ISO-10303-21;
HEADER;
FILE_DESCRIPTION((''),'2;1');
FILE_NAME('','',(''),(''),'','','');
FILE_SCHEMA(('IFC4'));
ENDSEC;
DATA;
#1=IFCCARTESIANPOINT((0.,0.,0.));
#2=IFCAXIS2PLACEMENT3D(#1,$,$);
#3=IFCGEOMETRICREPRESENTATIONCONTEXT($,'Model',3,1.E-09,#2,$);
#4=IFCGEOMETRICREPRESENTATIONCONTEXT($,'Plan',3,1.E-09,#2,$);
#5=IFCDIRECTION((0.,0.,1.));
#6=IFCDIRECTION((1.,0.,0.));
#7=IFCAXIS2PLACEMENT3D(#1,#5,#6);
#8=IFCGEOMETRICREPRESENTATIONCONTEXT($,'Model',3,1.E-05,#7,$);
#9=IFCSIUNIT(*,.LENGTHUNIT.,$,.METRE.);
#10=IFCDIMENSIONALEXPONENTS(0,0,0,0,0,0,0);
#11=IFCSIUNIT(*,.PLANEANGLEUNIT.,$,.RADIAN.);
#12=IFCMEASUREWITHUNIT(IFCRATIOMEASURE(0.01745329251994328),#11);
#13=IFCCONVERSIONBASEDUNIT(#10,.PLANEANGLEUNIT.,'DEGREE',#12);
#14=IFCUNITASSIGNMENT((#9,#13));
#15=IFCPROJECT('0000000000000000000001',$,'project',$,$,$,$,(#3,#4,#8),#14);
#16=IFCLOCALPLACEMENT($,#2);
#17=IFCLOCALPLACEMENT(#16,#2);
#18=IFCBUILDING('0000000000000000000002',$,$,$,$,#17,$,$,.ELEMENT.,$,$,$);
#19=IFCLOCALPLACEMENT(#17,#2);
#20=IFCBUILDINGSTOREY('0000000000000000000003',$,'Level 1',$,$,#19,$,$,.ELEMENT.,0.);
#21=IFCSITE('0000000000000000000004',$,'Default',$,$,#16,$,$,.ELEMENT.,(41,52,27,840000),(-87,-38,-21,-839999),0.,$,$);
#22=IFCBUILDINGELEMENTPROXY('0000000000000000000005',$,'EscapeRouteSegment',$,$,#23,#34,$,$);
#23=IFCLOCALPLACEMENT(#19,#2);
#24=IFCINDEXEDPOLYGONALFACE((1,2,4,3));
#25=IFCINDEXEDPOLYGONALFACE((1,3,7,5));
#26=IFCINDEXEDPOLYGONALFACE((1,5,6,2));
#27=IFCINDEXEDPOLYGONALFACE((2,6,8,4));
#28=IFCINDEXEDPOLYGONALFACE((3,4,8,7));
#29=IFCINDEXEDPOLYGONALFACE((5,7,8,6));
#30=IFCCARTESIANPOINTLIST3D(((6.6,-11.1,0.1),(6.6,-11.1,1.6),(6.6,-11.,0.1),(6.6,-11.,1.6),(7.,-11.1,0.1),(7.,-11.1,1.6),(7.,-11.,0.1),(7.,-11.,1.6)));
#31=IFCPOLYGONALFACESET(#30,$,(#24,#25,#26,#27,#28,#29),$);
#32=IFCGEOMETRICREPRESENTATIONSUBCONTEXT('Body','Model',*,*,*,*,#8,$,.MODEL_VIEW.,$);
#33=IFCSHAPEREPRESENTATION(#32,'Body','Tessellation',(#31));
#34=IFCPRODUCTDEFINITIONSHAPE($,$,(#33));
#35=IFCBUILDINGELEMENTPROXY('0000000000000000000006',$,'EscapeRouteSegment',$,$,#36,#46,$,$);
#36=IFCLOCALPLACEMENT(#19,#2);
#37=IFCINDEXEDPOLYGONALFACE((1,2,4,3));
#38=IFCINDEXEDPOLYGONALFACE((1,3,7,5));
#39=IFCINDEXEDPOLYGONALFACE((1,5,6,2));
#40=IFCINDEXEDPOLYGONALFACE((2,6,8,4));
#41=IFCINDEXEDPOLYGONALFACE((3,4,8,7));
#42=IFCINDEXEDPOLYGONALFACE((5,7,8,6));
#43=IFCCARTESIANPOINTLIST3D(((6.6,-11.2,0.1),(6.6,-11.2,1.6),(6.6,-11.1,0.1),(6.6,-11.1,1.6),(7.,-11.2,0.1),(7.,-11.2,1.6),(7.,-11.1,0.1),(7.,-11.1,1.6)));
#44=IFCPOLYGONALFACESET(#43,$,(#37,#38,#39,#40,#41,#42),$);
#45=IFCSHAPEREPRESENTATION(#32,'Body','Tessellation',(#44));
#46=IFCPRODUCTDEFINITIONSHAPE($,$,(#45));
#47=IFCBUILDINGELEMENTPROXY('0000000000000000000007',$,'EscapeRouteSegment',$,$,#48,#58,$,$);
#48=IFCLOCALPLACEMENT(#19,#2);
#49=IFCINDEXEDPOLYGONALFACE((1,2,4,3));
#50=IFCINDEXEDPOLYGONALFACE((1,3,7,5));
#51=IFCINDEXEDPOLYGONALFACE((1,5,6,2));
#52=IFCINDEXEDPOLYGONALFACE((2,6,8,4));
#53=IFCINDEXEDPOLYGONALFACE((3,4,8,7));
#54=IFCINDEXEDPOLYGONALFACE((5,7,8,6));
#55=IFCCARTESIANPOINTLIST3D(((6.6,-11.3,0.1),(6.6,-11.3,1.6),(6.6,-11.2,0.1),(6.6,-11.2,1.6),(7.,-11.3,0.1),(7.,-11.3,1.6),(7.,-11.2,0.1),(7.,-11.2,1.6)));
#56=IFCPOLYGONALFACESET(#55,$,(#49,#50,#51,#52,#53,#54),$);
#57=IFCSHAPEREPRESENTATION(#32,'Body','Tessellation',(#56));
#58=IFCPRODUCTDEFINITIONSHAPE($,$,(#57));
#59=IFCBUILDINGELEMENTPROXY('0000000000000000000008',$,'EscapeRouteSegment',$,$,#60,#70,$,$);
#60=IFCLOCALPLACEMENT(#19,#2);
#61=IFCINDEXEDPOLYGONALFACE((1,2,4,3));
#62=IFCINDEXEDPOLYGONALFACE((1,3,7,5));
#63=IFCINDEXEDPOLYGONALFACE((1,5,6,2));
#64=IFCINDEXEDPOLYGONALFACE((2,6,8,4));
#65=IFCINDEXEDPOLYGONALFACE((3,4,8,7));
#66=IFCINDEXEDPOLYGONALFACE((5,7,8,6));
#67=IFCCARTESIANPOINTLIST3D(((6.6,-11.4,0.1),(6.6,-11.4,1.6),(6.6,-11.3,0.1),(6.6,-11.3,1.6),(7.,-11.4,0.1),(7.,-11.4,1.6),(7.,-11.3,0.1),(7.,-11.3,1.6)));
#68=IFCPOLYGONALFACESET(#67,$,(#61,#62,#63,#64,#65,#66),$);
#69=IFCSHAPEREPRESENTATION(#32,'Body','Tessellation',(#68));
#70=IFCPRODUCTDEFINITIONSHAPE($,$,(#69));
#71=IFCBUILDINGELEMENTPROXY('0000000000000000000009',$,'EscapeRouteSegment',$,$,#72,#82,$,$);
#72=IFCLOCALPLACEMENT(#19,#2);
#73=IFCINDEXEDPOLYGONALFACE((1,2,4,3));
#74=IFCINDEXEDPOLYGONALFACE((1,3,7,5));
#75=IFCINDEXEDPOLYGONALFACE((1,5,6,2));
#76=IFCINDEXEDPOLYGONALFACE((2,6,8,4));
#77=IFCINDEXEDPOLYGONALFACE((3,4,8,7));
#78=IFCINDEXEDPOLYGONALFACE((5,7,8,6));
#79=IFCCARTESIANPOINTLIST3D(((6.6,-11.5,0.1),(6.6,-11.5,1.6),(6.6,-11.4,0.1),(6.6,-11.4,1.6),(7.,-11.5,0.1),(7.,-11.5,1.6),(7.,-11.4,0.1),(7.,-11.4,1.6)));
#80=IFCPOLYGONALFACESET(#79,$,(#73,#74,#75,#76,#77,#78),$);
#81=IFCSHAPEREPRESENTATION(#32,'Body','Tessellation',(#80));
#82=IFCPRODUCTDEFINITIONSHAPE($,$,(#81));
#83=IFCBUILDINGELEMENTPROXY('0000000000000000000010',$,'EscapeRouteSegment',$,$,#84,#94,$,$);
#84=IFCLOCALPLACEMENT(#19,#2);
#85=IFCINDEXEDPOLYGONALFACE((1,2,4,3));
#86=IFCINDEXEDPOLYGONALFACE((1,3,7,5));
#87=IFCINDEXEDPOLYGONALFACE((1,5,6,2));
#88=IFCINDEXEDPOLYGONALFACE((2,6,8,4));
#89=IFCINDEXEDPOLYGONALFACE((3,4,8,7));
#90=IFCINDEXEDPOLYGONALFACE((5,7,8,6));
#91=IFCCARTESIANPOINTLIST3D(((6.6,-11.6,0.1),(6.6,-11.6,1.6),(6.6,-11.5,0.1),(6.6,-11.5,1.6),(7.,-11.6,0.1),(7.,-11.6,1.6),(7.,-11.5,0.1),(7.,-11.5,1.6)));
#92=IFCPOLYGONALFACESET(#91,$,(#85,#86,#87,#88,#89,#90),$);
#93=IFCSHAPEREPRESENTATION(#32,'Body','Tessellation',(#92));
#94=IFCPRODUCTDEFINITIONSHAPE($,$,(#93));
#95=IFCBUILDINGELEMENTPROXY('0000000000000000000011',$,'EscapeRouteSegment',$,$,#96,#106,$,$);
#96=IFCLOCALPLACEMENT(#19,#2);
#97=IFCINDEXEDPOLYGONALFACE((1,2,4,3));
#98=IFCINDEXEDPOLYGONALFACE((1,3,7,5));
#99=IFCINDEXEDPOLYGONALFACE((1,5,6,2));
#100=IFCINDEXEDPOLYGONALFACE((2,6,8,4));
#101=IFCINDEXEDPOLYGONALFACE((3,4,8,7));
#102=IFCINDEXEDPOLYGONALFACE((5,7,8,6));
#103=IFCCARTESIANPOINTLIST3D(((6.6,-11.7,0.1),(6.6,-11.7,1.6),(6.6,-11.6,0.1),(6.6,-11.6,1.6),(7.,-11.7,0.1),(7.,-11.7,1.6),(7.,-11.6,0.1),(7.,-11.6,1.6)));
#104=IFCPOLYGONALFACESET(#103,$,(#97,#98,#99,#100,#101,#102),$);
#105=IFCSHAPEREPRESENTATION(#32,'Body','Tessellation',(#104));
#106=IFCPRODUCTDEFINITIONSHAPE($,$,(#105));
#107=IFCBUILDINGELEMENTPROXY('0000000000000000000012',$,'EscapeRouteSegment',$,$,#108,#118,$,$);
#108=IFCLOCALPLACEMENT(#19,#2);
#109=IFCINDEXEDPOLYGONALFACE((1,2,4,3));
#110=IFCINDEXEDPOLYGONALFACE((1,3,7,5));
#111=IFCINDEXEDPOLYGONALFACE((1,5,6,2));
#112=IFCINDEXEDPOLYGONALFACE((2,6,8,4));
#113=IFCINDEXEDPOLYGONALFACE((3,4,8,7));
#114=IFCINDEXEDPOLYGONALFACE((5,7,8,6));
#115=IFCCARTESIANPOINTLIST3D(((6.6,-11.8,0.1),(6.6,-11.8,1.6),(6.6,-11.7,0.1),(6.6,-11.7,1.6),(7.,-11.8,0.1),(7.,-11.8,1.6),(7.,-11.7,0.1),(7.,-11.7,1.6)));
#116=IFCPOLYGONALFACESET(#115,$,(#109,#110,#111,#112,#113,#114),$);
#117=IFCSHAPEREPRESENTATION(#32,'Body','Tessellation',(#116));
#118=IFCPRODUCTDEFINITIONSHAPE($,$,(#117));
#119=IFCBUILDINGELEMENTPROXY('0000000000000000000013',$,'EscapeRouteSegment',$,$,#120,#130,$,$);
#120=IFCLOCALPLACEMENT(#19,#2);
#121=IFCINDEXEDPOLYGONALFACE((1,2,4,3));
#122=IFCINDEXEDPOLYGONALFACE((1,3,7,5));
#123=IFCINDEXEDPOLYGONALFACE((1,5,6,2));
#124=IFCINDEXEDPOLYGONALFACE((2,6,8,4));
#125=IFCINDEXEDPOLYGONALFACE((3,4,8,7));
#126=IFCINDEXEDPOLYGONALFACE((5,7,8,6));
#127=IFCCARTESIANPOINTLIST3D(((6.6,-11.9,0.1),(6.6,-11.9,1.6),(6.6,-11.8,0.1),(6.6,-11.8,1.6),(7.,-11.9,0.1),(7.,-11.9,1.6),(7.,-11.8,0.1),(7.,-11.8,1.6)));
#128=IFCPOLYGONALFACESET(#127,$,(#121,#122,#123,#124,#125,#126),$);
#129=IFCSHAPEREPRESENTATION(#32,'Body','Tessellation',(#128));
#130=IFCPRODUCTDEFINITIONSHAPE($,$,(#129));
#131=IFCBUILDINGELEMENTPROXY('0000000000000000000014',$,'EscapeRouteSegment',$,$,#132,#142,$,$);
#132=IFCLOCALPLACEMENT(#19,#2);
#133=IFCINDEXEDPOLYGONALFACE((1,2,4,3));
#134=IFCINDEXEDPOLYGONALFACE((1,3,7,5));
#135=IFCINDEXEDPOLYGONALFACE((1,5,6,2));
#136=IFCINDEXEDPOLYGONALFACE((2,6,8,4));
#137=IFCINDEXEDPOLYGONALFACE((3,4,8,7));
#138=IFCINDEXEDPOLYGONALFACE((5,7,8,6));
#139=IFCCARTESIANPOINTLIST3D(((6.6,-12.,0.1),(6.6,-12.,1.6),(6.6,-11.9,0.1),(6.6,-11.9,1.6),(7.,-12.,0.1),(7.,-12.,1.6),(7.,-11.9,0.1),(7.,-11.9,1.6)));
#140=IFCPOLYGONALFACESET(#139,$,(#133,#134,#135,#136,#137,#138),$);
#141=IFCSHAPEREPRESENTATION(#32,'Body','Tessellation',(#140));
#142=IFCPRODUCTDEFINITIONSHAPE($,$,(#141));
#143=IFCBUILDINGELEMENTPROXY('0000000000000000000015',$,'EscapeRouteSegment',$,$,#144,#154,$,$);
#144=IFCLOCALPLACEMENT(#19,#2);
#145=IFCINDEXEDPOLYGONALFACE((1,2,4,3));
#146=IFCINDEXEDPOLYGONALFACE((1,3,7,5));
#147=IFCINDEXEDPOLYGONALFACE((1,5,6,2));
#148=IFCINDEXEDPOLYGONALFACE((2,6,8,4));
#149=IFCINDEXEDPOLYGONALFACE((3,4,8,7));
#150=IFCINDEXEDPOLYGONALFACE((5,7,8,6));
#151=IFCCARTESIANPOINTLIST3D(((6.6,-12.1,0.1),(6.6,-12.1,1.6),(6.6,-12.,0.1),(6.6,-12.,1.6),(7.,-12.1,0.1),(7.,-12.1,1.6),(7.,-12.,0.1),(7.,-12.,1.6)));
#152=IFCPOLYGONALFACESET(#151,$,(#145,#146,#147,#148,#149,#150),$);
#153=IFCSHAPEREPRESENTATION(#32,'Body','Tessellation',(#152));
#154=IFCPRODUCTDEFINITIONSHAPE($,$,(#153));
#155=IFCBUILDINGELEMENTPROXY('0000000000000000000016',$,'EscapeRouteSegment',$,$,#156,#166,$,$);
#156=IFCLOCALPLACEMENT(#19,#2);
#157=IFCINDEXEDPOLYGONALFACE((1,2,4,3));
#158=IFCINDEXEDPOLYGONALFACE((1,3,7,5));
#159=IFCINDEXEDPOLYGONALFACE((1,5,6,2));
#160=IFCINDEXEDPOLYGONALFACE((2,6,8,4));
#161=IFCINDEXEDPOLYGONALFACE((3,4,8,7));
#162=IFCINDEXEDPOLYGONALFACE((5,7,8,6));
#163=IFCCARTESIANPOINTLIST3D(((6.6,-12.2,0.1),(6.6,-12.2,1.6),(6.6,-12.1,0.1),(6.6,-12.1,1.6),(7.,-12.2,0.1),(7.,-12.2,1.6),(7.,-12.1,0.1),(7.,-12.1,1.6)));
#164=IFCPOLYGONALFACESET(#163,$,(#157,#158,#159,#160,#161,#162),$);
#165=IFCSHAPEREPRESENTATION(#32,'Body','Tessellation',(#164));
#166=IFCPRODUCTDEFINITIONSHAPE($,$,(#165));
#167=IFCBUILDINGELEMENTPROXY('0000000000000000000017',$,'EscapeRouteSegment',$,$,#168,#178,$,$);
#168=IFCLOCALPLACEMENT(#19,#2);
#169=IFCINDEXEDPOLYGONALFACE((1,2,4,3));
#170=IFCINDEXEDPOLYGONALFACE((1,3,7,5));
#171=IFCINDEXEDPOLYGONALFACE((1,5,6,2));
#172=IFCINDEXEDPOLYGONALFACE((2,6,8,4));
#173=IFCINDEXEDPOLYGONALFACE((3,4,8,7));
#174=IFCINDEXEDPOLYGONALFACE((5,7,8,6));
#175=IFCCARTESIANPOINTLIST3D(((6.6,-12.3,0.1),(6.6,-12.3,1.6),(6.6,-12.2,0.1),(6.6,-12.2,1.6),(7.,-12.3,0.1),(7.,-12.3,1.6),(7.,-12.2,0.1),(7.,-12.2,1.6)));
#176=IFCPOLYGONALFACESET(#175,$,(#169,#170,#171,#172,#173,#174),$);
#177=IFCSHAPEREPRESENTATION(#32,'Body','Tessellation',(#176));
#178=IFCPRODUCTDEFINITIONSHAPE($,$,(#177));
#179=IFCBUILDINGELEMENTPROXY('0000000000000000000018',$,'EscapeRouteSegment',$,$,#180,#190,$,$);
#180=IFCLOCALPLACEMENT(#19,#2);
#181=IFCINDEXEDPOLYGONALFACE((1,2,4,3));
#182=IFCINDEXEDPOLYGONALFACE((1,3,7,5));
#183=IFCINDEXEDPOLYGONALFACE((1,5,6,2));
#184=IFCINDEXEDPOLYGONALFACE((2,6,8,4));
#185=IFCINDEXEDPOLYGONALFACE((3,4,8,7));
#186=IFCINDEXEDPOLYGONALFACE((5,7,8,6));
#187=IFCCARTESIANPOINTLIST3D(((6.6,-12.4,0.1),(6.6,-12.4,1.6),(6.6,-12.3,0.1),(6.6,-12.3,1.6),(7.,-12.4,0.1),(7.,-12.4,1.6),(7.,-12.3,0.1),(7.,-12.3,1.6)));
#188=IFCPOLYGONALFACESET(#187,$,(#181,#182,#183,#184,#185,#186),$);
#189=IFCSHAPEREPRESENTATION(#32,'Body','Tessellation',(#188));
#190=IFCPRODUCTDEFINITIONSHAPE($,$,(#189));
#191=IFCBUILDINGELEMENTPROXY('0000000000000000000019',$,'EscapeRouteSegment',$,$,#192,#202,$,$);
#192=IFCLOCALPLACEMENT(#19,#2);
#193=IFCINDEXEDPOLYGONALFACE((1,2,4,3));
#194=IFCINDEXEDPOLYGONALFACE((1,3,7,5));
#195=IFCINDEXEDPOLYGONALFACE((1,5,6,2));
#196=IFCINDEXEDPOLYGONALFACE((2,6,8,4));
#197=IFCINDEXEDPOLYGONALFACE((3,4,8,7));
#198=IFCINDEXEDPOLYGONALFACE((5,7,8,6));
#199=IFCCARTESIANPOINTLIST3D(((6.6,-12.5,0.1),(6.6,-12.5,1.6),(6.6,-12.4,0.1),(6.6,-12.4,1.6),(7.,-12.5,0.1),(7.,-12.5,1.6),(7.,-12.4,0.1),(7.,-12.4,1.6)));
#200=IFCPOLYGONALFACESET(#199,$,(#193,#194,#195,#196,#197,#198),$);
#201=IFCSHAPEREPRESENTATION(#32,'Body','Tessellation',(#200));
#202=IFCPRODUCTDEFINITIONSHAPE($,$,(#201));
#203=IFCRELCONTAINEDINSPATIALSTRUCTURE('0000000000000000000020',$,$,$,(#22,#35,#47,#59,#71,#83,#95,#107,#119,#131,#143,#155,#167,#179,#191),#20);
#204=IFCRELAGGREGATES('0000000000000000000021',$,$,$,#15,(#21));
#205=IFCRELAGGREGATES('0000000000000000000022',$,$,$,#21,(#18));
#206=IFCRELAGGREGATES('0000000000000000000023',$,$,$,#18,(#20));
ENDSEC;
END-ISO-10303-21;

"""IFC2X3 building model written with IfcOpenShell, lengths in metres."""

from ifc_helpers import new_model, entity, si_unit, converted_unit, frame, origin, origin_with_axes, place, context, subcontext, project, spatial, polyline, outline, extrude, element, save


model = new_model("IFC2X3")

# Units and contexts
model_context_1 = context("Model", 3, precision=1e-09, world=origin())
plan_context = context("Plan", 3, precision=1e-09, world=origin())
model_context_2 = context("Model", 3, precision=1e-05, world=origin_with_axes())
body_context = subcontext(model_context_2, "Body", "Model", "MODEL_VIEW")
ifc_project = project(units=[si_unit("LENGTHUNIT", "METRE"), converted_unit("PLANEANGLEUNIT", "DEGREE", entity("IfcRatioMeasure", 0.01745329251994328), si_unit("PLANEANGLEUNIT", "RADIAN"), dimensions=[0, 0, 0, 0, 0, 0, 0])], contexts=[model_context_1, plan_context, model_context_2])

# Site, building, storey
site_placement = place(None, origin())
site = spatial("IfcSite", under=ifc_project, at=site_placement, Name="Default", CompositionType="ELEMENT", RefLatitude=(41, 52, 27, 840000), RefLongitude=(-87, -38, -21, -839999), RefElevation=0.0)
building_placement = place(site_placement, origin())
building = spatial("IfcBuilding", under=site, at=building_placement, CompositionType="ELEMENT")
storey_placement = place(building_placement, origin())
storey = spatial("IfcBuildingStorey", under=building, at=storey_placement, Name="Level 1", CompositionType="ELEMENT", Elevation=0.0)

# Building element proxies
proxy_1_placement = place(storey_placement, frame((6.8, -11.0, 0.1), z_axis=(0.0, 0.0, 1.0), x_axis=(0.0, -1.0, 0.0)))
element("IfcBuildingElementProxy", 1, at=proxy_1_placement, inside=storey, Name="EscapeRouteSegment", context=body_context, shape_type="SweptSolid", body=[
    extrude(outline(polyline([(0.0, -0.2), (0.0, 0.2), (0.1, 0.2), (0.1, -0.2), (0.0, -0.2)])), origin_with_axes(), (0.0, 0.0, 1.0), 1.5),
])
proxy_2_placement = place(storey_placement, frame((6.8, -11.1, 0.1), z_axis=(0.0, 0.0, 1.0), x_axis=(0.0, -1.0, 0.0)))
element("IfcBuildingElementProxy", 2, at=proxy_2_placement, inside=storey, Name="EscapeRouteSegment", context=body_context, shape_type="SweptSolid", body=[
    extrude(outline(polyline([(0.0, -0.2), (0.0, 0.2), (0.1, 0.2), (0.1, -0.2), (0.0, -0.2)])), origin_with_axes(), (0.0, 0.0, 1.0), 1.5),
])
proxy_3_placement = place(storey_placement, frame((6.8, -11.2, 0.1), z_axis=(0.0, 0.0, 1.0), x_axis=(0.0, -1.0, 0.0)))
element("IfcBuildingElementProxy", 3, at=proxy_3_placement, inside=storey, Name="EscapeRouteSegment", context=body_context, shape_type="SweptSolid", body=[
    extrude(outline(polyline([(0.0, -0.2), (0.0, 0.2), (0.1, 0.2), (0.1, -0.2), (0.0, -0.2)])), origin_with_axes(), (0.0, 0.0, 1.0), 1.5),
])
proxy_4_placement = place(storey_placement, frame((6.8, -11.3, 0.1), z_axis=(0.0, 0.0, 1.0), x_axis=(0.0, -1.0, 0.0)))
element("IfcBuildingElementProxy", 4, at=proxy_4_placement, inside=storey, Name="EscapeRouteSegment", context=body_context, shape_type="SweptSolid", body=[
    extrude(outline(polyline([(0.0, -0.2), (0.0, 0.2), (0.1, 0.2), (0.1, -0.2), (0.0, -0.2)])), origin_with_axes(), (0.0, 0.0, 1.0), 1.5),
])
for number, where, z_axis, x_axis, name in (
    (5, (6.8, -11.4, 0.1), (0.0, 0.0, 1.0), (0.0, -1.0, 0.0), "EscapeRouteSegment"),
    (6, (6.8, -11.5, 0.1), (0.0, 0.0, 1.0), (0.0, -1.0, 0.0), "EscapeRouteSegment"),
):
    element("IfcBuildingElementProxy", number, at=place(storey_placement, frame(where, z_axis=z_axis, x_axis=x_axis)), inside=storey, Name=name, context=body_context, shape_type="SweptSolid", body=[
        extrude(outline(polyline([(0.0, -0.2), (0.0, 0.2), (0.1, 0.2), (0.1, -0.2), (0.0, -0.2)])), origin_with_axes(), (0.0, 0.0, 1.0), 1.5),
    ])
proxy_5_placement = place(storey_placement, frame((6.8, -11.6, 0.1), z_axis=(0.0, 0.0, 1.0), x_axis=(0.0, -1.0, 0.0)))
element("IfcBuildingElementProxy", 7, at=proxy_5_placement, inside=storey, Name="EscapeRouteSegment", context=body_context, shape_type="SweptSolid", body=[
    extrude(outline(polyline([(0.0, -0.2), (0.0, 0.2), (0.1, 0.2), (0.1, -0.2), (0.0, -0.2)])), origin_with_axes(), (0.0, 0.0, 1.0), 1.5),
])
proxy_6_placement = place(storey_placement, frame((6.8, -11.7, 0.1), z_axis=(0.0, 0.0, 1.0), x_axis=(0.0, -1.0, 0.0)))
element("IfcBuildingElementProxy", 8, at=proxy_6_placement, inside=storey, Name="EscapeRouteSegment", context=body_context, shape_type="SweptSolid", body=[
    extrude(outline(polyline([(0.0, -0.2), (0.0, 0.2), (0.1, 0.2), (0.1, -0.2), (0.0, -0.2)])), origin_with_axes(), (0.0, 0.0, 1.0), 1.5),
])
proxy_7_placement = place(storey_placement, frame((6.8, -11.8, 0.1), z_axis=(0.0, 0.0, 1.0), x_axis=(0.0, -1.0, 0.0)))
element("IfcBuildingElementProxy", 9, at=proxy_7_placement, inside=storey, Name="EscapeRouteSegment", context=body_context, shape_type="SweptSolid", body=[
    extrude(outline(polyline([(0.0, -0.2), (0.0, 0.2), (0.1, 0.2), (0.1, -0.2), (0.0, -0.2)])), origin_with_axes(), (0.0, 0.0, 1.0), 1.5),
])
for number, where, z_axis, x_axis, name in (
    (10, (6.8, -11.9, 0.1), (0.0, 0.0, 1.0), (0.0, -1.0, 0.0), "EscapeRouteSegment"),
    (11, (6.8, -12.0, 0.1), (0.0, 0.0, 1.0), (0.0, -1.0, 0.0), "EscapeRouteSegment"),
):
    element("IfcBuildingElementProxy", number, at=place(storey_placement, frame(where, z_axis=z_axis, x_axis=x_axis)), inside=storey, Name=name, context=body_context, shape_type="SweptSolid", body=[
        extrude(outline(polyline([(0.0, -0.2), (0.0, 0.2), (0.1, 0.2), (0.1, -0.2), (0.0, -0.2)])), origin_with_axes(), (0.0, 0.0, 1.0), 1.5),
    ])
proxy_8_placement = place(storey_placement, frame((6.8, -12.1, 0.1), z_axis=(0.0, 0.0, 1.0), x_axis=(0.0, -1.0, 0.0)))
element("IfcBuildingElementProxy", 12, at=proxy_8_placement, inside=storey, Name="EscapeRouteSegment", context=body_context, shape_type="SweptSolid", body=[
    extrude(outline(polyline([(0.0, -0.2), (0.0, 0.2), (0.1, 0.2), (0.1, -0.2), (0.0, -0.2)])), origin_with_axes(), (0.0, 0.0, 1.0), 1.5),
])
proxy_9_placement = place(storey_placement, frame((6.8, -12.2, 0.1), z_axis=(0.0, 0.0, 1.0), x_axis=(0.0, -1.0, 0.0)))
element("IfcBuildingElementProxy", 13, at=proxy_9_placement, inside=storey, Name="EscapeRouteSegment", context=body_context, shape_type="SweptSolid", body=[
    extrude(outline(polyline([(0.0, -0.2), (0.0, 0.2), (0.1, 0.2), (0.1, -0.2), (0.0, -0.2)])), origin_with_axes(), (0.0, 0.0, 1.0), 1.5),
])
proxy_10_placement = place(storey_placement, frame((6.8, -12.3, 0.1), z_axis=(0.0, 0.0, 1.0), x_axis=(0.0, -1.0, 0.0)))
element("IfcBuildingElementProxy", 14, at=proxy_10_placement, inside=storey, Name="EscapeRouteSegment", context=body_context, shape_type="SweptSolid", body=[
    extrude(outline(polyline([(0.0, -0.2), (0.0, 0.2), (0.1, 0.2), (0.1, -0.2), (0.0, -0.2)])), origin_with_axes(), (0.0, 0.0, 1.0), 1.5),
])
proxy_11_placement = place(storey_placement, frame((6.8, -12.4, 0.1), z_axis=(0.0, 0.0, 1.0), x_axis=(0.0, -1.0, 0.0)))
element("IfcBuildingElementProxy", 15, at=proxy_11_placement, inside=storey, Name="EscapeRouteSegment", context=body_context, shape_type="SweptSolid", body=[
    extrude(outline(polyline([(0.0, -0.2), (0.0, 0.2), (0.1, 0.2), (0.1, -0.2), (0.0, -0.2)])), origin_with_axes(), (0.0, 0.0, 1.0), 1.5),
])

save(model, "model.ifc")
